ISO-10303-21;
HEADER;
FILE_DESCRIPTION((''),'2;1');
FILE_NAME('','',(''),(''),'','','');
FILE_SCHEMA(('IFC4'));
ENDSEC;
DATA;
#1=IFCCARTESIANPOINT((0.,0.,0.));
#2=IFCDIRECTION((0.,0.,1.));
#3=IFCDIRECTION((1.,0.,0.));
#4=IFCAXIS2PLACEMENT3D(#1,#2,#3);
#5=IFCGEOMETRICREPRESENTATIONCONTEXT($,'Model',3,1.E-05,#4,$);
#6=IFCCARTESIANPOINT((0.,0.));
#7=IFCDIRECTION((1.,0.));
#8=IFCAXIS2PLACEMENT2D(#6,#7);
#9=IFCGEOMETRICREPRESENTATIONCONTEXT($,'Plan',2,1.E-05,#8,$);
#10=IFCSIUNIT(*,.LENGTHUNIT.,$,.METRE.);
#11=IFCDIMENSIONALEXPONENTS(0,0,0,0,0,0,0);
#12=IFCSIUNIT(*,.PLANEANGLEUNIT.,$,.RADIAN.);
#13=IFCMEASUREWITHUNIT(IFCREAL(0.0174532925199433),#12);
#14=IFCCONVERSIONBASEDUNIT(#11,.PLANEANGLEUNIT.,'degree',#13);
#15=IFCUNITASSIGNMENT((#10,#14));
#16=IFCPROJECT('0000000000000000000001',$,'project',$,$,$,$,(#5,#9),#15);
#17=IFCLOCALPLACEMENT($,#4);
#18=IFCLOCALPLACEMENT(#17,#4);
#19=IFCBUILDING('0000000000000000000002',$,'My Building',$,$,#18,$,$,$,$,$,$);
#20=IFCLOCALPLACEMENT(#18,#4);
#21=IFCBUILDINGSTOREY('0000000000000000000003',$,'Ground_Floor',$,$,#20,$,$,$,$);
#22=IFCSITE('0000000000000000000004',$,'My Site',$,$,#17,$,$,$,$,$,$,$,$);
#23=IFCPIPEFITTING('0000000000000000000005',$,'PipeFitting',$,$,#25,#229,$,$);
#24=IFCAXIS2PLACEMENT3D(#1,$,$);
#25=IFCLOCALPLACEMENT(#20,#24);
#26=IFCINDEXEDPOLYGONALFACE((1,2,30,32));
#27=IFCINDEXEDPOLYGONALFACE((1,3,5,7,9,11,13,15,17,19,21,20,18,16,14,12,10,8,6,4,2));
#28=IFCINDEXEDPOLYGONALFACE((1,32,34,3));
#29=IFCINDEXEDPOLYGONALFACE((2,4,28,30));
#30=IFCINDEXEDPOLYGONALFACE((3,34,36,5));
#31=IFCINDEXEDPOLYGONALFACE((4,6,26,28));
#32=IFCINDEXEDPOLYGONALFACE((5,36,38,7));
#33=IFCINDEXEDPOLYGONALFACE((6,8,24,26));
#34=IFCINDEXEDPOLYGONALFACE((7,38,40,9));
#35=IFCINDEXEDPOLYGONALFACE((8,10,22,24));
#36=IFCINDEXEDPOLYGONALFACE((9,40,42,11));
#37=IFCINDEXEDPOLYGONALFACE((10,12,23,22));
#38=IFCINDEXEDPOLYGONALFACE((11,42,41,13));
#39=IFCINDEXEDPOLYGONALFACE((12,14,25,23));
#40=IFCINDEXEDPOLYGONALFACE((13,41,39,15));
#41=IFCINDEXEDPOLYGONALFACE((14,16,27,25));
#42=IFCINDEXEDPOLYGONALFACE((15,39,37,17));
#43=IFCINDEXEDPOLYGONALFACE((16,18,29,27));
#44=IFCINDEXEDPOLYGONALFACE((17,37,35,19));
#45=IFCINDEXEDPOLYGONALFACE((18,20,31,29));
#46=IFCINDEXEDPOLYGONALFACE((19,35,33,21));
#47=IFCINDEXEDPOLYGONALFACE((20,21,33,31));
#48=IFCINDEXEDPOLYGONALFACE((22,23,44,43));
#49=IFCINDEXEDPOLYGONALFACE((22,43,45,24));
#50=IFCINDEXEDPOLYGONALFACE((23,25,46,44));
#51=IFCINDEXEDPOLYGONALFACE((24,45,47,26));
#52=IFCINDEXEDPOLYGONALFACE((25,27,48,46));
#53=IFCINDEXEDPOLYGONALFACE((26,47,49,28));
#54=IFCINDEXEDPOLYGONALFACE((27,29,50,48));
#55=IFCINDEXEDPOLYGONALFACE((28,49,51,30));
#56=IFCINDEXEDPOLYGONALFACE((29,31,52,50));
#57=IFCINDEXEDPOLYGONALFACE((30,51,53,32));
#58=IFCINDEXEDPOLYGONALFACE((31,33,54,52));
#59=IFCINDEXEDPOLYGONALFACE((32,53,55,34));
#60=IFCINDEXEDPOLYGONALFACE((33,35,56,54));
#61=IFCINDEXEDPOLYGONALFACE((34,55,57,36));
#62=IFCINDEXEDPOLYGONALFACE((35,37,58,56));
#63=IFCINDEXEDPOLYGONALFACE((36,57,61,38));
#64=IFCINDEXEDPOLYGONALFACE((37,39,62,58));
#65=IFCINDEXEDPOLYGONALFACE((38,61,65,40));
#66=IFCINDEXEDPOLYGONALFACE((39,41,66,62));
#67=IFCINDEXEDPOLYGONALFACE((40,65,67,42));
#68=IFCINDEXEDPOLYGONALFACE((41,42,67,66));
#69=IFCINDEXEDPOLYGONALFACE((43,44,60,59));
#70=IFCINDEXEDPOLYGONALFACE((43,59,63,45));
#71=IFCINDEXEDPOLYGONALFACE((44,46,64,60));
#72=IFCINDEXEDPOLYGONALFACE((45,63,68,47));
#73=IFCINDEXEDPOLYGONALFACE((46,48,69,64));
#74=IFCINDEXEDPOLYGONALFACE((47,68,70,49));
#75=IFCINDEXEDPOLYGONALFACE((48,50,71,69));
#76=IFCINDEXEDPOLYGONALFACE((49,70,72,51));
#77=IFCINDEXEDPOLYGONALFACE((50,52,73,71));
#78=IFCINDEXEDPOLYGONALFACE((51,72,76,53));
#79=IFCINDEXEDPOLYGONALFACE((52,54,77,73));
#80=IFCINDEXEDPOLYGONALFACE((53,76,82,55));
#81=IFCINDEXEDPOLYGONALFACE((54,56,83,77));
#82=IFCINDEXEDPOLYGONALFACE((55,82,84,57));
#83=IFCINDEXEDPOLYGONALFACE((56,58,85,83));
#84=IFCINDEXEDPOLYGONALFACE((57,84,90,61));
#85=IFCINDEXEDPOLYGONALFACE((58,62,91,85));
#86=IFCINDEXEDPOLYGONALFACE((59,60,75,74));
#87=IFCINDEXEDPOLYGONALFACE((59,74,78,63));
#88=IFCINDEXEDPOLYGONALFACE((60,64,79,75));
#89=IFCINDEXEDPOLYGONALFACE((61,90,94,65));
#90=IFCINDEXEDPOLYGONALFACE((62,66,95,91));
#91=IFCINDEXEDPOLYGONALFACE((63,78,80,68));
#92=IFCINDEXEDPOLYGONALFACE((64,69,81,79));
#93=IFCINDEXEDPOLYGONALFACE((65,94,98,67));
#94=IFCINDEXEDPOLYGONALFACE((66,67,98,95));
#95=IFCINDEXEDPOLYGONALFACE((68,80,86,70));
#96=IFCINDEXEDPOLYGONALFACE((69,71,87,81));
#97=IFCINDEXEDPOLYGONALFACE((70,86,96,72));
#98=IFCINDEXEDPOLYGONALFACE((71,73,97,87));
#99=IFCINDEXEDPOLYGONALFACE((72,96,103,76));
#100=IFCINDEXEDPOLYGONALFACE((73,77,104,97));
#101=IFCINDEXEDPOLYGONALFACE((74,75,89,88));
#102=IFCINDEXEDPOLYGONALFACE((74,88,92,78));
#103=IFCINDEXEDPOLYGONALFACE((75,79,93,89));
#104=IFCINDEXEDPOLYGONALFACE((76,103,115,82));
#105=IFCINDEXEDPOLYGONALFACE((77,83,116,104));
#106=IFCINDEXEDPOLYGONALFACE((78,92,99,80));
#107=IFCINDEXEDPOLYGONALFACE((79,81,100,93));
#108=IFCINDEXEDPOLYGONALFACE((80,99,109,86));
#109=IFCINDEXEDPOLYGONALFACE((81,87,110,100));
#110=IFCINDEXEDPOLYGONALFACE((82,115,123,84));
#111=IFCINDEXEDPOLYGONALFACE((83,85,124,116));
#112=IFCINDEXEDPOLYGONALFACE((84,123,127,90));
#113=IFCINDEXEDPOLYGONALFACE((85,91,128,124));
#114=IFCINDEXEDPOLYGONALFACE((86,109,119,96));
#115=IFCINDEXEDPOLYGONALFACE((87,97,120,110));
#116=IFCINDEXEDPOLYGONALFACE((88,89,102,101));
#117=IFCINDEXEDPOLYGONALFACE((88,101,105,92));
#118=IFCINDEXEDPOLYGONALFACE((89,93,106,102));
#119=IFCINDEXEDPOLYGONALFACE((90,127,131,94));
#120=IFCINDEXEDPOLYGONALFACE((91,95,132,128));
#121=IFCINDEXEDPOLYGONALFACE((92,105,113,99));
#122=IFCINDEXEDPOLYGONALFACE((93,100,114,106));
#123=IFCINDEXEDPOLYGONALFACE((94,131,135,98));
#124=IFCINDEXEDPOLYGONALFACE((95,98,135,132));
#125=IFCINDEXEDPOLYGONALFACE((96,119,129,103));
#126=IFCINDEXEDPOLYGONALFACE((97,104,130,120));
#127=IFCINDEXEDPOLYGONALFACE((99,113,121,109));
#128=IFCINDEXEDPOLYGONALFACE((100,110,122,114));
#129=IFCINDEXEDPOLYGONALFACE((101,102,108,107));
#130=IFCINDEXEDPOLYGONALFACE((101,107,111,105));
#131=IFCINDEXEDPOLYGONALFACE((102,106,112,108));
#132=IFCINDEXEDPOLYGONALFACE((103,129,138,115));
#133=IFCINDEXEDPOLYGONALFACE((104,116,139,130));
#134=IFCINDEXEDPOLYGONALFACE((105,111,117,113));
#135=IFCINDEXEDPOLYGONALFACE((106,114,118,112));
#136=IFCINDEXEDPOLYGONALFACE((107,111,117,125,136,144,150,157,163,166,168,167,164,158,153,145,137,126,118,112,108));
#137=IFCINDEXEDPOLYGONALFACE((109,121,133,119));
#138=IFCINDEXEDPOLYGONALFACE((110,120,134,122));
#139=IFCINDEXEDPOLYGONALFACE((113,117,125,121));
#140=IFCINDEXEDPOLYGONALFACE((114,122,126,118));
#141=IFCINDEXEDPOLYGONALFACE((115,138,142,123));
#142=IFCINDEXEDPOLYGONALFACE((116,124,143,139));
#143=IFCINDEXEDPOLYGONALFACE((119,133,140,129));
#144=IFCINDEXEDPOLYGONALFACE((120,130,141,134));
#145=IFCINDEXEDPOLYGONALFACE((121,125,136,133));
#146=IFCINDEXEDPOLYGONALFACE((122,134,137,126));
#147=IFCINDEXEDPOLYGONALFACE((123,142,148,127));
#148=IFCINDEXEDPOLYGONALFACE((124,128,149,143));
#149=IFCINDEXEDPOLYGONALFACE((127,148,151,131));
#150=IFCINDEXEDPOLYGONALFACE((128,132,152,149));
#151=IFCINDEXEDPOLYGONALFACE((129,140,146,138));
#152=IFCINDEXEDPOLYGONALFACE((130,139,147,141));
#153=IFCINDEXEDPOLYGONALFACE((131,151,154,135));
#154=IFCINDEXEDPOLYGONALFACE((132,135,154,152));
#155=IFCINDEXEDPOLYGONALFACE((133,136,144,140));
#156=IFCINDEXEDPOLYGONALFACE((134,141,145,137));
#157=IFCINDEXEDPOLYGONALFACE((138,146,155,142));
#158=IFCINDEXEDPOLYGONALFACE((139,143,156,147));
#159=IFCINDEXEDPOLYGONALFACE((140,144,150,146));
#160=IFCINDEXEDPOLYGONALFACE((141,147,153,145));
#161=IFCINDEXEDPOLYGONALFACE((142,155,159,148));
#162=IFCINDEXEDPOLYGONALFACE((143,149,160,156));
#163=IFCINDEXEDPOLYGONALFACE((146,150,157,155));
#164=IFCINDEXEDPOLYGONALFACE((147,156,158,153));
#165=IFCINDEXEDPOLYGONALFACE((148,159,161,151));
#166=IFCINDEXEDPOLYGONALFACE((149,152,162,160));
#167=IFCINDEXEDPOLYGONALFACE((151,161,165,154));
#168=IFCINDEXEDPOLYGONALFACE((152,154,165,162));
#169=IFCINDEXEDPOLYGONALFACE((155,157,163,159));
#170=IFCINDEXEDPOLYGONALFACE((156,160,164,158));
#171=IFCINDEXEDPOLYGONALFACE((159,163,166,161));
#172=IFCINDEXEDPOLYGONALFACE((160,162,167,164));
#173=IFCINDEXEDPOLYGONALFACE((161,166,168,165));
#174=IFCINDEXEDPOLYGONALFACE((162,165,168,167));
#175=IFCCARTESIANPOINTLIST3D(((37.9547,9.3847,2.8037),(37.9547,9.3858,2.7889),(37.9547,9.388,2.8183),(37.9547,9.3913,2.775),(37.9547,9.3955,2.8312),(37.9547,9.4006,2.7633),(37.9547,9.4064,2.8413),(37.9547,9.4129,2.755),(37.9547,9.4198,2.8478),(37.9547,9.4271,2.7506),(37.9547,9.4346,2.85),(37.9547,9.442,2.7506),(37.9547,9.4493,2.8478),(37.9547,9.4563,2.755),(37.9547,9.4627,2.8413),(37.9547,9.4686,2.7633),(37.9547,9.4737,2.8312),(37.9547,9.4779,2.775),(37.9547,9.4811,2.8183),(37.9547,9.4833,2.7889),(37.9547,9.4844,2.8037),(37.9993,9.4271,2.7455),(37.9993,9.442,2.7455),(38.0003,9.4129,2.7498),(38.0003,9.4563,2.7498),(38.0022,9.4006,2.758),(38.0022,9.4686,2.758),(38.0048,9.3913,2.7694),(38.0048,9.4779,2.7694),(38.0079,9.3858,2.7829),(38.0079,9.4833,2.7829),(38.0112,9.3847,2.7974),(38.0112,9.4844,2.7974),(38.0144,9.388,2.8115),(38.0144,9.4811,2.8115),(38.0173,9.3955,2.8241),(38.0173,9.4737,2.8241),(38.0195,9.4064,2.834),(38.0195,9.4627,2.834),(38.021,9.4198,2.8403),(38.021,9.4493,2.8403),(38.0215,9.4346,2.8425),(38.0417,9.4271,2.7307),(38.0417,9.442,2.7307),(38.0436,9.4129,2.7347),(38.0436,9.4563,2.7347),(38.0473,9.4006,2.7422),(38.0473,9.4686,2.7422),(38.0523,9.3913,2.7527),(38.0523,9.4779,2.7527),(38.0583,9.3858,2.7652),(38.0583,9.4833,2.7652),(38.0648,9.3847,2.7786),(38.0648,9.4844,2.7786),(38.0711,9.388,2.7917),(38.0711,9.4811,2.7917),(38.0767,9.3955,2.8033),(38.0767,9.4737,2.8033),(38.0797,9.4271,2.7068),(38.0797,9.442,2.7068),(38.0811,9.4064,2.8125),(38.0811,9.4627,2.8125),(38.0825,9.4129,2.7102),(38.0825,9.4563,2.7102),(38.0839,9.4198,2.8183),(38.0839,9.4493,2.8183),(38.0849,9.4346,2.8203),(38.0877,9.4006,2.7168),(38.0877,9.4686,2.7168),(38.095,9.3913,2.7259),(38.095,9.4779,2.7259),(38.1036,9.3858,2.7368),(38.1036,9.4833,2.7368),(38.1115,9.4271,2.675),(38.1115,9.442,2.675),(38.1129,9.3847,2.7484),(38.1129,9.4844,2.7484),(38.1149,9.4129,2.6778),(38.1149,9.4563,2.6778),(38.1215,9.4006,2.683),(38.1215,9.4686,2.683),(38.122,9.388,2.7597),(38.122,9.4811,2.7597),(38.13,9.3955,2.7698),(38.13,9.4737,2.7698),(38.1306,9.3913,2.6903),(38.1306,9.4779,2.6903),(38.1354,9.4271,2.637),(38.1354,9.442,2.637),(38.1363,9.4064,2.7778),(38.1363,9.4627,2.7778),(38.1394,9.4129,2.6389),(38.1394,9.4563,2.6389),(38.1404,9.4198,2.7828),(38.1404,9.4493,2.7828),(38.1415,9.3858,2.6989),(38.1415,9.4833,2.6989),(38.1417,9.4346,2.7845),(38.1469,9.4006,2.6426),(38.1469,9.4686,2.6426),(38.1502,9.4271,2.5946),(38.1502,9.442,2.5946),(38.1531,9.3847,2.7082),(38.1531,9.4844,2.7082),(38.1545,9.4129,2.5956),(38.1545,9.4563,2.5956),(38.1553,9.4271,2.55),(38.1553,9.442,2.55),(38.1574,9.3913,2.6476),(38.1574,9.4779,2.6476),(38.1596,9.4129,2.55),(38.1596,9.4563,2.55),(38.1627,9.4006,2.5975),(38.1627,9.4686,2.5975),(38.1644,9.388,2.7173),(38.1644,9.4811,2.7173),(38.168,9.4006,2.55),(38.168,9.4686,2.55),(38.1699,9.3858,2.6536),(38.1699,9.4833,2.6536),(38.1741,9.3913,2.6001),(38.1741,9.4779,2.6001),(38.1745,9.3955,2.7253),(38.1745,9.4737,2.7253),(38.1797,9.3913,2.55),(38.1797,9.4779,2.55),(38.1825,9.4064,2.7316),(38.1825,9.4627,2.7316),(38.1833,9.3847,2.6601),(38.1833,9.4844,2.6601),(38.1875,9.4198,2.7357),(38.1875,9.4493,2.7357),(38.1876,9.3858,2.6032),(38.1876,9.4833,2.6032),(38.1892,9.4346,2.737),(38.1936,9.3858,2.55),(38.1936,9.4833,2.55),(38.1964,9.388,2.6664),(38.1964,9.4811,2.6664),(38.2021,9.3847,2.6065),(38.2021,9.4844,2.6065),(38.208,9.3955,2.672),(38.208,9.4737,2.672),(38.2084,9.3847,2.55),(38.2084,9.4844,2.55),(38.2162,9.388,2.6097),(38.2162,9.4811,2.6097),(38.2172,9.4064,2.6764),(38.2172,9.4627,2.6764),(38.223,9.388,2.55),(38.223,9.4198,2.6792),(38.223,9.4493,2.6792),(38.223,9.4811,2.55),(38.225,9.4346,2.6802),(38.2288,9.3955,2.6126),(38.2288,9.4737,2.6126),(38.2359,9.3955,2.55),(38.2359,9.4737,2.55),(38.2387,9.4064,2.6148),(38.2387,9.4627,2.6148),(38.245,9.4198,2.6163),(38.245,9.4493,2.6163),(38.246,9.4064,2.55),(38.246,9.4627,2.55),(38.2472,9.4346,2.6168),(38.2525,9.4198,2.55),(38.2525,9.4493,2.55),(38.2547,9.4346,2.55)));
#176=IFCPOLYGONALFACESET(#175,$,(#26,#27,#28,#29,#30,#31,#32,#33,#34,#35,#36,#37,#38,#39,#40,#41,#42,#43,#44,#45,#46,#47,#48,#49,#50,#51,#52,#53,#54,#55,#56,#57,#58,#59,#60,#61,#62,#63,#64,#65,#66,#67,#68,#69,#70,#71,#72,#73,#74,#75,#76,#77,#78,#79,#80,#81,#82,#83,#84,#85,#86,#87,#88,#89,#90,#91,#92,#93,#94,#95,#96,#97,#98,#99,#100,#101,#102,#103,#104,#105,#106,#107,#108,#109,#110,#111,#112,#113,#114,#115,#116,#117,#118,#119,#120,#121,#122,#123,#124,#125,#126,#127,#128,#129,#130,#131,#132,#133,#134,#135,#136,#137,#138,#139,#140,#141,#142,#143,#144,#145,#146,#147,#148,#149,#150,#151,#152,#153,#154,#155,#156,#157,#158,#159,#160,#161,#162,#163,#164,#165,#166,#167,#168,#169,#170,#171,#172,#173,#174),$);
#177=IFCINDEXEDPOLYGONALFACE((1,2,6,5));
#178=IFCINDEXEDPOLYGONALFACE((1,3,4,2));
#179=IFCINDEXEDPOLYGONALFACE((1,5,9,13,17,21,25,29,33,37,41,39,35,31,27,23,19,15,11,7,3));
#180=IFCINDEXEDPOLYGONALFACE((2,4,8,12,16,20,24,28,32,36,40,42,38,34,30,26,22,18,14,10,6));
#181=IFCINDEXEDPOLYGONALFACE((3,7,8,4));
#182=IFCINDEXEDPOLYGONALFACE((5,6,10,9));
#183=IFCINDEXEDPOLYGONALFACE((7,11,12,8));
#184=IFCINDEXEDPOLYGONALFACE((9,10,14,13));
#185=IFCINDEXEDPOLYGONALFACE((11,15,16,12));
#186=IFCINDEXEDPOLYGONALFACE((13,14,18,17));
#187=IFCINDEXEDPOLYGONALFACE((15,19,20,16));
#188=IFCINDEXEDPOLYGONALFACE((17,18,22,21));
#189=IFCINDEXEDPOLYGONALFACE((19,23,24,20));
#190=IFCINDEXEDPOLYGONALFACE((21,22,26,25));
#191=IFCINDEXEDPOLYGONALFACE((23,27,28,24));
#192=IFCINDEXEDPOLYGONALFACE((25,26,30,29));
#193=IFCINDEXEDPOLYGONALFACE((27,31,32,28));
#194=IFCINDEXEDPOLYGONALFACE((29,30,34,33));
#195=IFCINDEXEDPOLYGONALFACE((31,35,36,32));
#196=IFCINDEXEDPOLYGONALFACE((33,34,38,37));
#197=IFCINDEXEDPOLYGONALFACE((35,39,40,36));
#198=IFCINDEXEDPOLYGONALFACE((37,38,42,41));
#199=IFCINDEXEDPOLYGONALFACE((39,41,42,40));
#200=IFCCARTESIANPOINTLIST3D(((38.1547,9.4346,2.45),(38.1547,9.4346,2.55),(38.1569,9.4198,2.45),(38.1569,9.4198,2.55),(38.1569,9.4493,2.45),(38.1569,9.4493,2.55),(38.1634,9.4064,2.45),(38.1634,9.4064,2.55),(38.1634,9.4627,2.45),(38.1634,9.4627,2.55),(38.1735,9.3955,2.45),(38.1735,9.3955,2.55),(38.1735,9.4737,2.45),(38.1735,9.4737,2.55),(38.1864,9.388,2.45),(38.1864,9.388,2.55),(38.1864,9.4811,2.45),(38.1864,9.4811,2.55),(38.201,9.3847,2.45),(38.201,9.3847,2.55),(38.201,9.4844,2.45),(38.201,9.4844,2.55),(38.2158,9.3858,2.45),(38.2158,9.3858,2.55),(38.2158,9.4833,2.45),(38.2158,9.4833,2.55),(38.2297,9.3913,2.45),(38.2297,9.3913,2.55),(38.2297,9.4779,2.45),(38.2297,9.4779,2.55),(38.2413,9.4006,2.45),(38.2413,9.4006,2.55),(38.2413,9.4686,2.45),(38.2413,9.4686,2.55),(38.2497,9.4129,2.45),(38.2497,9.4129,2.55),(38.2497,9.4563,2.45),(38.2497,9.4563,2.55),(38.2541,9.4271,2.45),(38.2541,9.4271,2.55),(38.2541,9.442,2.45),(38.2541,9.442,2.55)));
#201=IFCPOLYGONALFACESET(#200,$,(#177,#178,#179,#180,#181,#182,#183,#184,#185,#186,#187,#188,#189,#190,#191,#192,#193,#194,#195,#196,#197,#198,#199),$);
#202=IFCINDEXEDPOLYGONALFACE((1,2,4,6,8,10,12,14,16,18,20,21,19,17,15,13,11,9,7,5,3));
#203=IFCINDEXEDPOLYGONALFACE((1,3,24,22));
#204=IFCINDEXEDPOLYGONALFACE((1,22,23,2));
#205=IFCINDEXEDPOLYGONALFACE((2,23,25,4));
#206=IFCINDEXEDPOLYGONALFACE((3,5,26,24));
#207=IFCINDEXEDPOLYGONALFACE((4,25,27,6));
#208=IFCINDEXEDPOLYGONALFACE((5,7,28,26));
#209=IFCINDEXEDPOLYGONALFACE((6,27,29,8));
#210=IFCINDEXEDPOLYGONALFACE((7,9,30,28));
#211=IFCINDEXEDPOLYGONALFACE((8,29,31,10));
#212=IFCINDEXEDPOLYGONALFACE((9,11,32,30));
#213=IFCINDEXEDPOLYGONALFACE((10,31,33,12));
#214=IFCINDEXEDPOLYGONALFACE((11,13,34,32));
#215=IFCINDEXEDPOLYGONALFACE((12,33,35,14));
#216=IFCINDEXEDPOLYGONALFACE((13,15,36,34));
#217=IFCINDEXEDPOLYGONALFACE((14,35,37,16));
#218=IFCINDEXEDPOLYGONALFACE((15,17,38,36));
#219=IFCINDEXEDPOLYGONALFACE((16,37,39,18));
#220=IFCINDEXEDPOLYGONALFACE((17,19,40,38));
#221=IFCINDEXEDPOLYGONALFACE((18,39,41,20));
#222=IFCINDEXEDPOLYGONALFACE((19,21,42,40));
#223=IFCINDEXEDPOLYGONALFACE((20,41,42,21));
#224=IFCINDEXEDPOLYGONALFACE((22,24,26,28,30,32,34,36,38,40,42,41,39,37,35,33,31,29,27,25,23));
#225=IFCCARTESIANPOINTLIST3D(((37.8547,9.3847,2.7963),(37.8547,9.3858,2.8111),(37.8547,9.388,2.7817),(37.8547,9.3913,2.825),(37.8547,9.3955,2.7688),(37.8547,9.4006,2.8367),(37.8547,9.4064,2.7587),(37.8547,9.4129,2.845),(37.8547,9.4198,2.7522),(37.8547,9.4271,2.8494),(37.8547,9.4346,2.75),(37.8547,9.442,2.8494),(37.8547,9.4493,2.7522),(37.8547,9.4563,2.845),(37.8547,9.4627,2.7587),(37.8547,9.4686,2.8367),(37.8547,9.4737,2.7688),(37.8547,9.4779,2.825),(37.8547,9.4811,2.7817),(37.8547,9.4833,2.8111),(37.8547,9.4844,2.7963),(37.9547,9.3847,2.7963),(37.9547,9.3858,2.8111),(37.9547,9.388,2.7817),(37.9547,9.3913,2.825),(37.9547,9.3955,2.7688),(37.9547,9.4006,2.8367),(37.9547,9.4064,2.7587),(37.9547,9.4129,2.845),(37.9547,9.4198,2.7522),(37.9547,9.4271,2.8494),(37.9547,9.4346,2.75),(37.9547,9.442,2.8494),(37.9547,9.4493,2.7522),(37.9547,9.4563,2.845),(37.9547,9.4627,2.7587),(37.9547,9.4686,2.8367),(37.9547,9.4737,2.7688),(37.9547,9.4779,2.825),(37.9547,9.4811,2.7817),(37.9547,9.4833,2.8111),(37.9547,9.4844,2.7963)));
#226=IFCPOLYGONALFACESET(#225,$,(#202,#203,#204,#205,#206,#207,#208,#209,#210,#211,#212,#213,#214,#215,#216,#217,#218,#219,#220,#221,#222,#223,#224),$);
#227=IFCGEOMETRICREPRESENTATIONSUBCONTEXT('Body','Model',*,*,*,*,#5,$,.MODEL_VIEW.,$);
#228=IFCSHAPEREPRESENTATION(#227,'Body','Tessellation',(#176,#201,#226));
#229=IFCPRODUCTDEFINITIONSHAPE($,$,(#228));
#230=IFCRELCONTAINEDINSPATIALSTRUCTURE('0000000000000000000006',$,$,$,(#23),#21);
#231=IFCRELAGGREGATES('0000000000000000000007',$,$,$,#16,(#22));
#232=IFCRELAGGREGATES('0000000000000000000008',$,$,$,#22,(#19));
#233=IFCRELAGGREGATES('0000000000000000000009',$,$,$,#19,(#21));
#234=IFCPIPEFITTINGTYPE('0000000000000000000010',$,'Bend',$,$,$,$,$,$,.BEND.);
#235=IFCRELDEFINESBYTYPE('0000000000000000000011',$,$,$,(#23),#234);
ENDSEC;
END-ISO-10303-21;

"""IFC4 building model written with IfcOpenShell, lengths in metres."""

from ifc_helpers import new_model, entity, si_unit, converted_unit, frame, origin_with_axes, origin_2d_with_axis, place, context, subcontext, project, spatial, circle, extrude, source, transform, mapped, type_object, type_shapes, element, save


model = new_model("IFC4")

# Units and contexts
model_context = context("Model", 3, precision=1e-05, world=origin_with_axes())
plan_context = context("Plan", 2, precision=1e-05, world=origin_2d_with_axis())
body_context = subcontext(model_context, "Body", "Model", "MODEL_VIEW")
ifc_project = project(units=[si_unit("LENGTHUNIT", "METRE"), converted_unit("PLANEANGLEUNIT", "degree", entity("IfcReal", 0.0174532925199433), si_unit("PLANEANGLEUNIT", "RADIAN"), dimensions=[0, 0, 0, 0, 0, 0, 0])], contexts=[model_context, plan_context])

# Site, building, storey
site_placement = place(None, origin_with_axes())
site = spatial("IfcSite", under=ifc_project, at=site_placement, Name="My Site")
building_placement = place(site_placement, origin_with_axes())
building = spatial("IfcBuilding", under=site, at=building_placement, Name="My Building")
storey_placement = place(building_placement, origin_with_axes())
storey = spatial("IfcBuildingStorey", under=building, at=storey_placement, Name="Ground_Floor")

# Pipe fitting
pipe_fitting_type = type_object("IfcPipeFittingType", Name="Bend", PredefinedType="BEND")
shared_shape = source(origin_with_axes(), body_context, "Body", "SolidModel", [
    entity("IfcSweptDiskSolid", entity("IfcIndexedPolyCurve", entity("IfcCartesianPointList3D", [[0.0, 0.0, -0.1], [0.0732, 0.0, -0.2768], [0.25, 0.0, -0.35]]), [entity("IfcArcIndex", [1, 2, 3])]), 0.05),
    extrude(circle(Radius=0.05), origin_with_axes(), (0.0, 0.0, -1.0), 0.1),
    extrude(circle(Radius=0.05), frame((0.25, 0.0, -0.35), z_axis=(1.0, 0.0, 0.0), x_axis=(0.0, 0.0, 1.0)), (0.0, 0.0, 1.0), 0.1),
])
type_shapes(pipe_fitting_type, [shared_shape])
for number, where, z_axis, x_axis, name in (
    (1, (38.2047, 9.4346, 2.45), (0.0, 0.0, -1.0), (-1.0, 0.0, 0.0), "PipeFitting"),
):
    element("IfcPipeFitting", number, at=place(storey_placement, frame(where, z_axis=z_axis, x_axis=x_axis)), inside=storey, type_object=pipe_fitting_type, Name=name, context=body_context, shape_type="MappedRepresentation", body=[
        mapped(shared_shape, transform((0.0, 0.0, 0.0), x_axis=(1.0, 0.0, 0.0), y_axis=(0.0, 1.0, 0.0), z_axis=(0.0, 0.0, 1.0), scale=1.0)),
    ])

save(model, "model.ifc")
